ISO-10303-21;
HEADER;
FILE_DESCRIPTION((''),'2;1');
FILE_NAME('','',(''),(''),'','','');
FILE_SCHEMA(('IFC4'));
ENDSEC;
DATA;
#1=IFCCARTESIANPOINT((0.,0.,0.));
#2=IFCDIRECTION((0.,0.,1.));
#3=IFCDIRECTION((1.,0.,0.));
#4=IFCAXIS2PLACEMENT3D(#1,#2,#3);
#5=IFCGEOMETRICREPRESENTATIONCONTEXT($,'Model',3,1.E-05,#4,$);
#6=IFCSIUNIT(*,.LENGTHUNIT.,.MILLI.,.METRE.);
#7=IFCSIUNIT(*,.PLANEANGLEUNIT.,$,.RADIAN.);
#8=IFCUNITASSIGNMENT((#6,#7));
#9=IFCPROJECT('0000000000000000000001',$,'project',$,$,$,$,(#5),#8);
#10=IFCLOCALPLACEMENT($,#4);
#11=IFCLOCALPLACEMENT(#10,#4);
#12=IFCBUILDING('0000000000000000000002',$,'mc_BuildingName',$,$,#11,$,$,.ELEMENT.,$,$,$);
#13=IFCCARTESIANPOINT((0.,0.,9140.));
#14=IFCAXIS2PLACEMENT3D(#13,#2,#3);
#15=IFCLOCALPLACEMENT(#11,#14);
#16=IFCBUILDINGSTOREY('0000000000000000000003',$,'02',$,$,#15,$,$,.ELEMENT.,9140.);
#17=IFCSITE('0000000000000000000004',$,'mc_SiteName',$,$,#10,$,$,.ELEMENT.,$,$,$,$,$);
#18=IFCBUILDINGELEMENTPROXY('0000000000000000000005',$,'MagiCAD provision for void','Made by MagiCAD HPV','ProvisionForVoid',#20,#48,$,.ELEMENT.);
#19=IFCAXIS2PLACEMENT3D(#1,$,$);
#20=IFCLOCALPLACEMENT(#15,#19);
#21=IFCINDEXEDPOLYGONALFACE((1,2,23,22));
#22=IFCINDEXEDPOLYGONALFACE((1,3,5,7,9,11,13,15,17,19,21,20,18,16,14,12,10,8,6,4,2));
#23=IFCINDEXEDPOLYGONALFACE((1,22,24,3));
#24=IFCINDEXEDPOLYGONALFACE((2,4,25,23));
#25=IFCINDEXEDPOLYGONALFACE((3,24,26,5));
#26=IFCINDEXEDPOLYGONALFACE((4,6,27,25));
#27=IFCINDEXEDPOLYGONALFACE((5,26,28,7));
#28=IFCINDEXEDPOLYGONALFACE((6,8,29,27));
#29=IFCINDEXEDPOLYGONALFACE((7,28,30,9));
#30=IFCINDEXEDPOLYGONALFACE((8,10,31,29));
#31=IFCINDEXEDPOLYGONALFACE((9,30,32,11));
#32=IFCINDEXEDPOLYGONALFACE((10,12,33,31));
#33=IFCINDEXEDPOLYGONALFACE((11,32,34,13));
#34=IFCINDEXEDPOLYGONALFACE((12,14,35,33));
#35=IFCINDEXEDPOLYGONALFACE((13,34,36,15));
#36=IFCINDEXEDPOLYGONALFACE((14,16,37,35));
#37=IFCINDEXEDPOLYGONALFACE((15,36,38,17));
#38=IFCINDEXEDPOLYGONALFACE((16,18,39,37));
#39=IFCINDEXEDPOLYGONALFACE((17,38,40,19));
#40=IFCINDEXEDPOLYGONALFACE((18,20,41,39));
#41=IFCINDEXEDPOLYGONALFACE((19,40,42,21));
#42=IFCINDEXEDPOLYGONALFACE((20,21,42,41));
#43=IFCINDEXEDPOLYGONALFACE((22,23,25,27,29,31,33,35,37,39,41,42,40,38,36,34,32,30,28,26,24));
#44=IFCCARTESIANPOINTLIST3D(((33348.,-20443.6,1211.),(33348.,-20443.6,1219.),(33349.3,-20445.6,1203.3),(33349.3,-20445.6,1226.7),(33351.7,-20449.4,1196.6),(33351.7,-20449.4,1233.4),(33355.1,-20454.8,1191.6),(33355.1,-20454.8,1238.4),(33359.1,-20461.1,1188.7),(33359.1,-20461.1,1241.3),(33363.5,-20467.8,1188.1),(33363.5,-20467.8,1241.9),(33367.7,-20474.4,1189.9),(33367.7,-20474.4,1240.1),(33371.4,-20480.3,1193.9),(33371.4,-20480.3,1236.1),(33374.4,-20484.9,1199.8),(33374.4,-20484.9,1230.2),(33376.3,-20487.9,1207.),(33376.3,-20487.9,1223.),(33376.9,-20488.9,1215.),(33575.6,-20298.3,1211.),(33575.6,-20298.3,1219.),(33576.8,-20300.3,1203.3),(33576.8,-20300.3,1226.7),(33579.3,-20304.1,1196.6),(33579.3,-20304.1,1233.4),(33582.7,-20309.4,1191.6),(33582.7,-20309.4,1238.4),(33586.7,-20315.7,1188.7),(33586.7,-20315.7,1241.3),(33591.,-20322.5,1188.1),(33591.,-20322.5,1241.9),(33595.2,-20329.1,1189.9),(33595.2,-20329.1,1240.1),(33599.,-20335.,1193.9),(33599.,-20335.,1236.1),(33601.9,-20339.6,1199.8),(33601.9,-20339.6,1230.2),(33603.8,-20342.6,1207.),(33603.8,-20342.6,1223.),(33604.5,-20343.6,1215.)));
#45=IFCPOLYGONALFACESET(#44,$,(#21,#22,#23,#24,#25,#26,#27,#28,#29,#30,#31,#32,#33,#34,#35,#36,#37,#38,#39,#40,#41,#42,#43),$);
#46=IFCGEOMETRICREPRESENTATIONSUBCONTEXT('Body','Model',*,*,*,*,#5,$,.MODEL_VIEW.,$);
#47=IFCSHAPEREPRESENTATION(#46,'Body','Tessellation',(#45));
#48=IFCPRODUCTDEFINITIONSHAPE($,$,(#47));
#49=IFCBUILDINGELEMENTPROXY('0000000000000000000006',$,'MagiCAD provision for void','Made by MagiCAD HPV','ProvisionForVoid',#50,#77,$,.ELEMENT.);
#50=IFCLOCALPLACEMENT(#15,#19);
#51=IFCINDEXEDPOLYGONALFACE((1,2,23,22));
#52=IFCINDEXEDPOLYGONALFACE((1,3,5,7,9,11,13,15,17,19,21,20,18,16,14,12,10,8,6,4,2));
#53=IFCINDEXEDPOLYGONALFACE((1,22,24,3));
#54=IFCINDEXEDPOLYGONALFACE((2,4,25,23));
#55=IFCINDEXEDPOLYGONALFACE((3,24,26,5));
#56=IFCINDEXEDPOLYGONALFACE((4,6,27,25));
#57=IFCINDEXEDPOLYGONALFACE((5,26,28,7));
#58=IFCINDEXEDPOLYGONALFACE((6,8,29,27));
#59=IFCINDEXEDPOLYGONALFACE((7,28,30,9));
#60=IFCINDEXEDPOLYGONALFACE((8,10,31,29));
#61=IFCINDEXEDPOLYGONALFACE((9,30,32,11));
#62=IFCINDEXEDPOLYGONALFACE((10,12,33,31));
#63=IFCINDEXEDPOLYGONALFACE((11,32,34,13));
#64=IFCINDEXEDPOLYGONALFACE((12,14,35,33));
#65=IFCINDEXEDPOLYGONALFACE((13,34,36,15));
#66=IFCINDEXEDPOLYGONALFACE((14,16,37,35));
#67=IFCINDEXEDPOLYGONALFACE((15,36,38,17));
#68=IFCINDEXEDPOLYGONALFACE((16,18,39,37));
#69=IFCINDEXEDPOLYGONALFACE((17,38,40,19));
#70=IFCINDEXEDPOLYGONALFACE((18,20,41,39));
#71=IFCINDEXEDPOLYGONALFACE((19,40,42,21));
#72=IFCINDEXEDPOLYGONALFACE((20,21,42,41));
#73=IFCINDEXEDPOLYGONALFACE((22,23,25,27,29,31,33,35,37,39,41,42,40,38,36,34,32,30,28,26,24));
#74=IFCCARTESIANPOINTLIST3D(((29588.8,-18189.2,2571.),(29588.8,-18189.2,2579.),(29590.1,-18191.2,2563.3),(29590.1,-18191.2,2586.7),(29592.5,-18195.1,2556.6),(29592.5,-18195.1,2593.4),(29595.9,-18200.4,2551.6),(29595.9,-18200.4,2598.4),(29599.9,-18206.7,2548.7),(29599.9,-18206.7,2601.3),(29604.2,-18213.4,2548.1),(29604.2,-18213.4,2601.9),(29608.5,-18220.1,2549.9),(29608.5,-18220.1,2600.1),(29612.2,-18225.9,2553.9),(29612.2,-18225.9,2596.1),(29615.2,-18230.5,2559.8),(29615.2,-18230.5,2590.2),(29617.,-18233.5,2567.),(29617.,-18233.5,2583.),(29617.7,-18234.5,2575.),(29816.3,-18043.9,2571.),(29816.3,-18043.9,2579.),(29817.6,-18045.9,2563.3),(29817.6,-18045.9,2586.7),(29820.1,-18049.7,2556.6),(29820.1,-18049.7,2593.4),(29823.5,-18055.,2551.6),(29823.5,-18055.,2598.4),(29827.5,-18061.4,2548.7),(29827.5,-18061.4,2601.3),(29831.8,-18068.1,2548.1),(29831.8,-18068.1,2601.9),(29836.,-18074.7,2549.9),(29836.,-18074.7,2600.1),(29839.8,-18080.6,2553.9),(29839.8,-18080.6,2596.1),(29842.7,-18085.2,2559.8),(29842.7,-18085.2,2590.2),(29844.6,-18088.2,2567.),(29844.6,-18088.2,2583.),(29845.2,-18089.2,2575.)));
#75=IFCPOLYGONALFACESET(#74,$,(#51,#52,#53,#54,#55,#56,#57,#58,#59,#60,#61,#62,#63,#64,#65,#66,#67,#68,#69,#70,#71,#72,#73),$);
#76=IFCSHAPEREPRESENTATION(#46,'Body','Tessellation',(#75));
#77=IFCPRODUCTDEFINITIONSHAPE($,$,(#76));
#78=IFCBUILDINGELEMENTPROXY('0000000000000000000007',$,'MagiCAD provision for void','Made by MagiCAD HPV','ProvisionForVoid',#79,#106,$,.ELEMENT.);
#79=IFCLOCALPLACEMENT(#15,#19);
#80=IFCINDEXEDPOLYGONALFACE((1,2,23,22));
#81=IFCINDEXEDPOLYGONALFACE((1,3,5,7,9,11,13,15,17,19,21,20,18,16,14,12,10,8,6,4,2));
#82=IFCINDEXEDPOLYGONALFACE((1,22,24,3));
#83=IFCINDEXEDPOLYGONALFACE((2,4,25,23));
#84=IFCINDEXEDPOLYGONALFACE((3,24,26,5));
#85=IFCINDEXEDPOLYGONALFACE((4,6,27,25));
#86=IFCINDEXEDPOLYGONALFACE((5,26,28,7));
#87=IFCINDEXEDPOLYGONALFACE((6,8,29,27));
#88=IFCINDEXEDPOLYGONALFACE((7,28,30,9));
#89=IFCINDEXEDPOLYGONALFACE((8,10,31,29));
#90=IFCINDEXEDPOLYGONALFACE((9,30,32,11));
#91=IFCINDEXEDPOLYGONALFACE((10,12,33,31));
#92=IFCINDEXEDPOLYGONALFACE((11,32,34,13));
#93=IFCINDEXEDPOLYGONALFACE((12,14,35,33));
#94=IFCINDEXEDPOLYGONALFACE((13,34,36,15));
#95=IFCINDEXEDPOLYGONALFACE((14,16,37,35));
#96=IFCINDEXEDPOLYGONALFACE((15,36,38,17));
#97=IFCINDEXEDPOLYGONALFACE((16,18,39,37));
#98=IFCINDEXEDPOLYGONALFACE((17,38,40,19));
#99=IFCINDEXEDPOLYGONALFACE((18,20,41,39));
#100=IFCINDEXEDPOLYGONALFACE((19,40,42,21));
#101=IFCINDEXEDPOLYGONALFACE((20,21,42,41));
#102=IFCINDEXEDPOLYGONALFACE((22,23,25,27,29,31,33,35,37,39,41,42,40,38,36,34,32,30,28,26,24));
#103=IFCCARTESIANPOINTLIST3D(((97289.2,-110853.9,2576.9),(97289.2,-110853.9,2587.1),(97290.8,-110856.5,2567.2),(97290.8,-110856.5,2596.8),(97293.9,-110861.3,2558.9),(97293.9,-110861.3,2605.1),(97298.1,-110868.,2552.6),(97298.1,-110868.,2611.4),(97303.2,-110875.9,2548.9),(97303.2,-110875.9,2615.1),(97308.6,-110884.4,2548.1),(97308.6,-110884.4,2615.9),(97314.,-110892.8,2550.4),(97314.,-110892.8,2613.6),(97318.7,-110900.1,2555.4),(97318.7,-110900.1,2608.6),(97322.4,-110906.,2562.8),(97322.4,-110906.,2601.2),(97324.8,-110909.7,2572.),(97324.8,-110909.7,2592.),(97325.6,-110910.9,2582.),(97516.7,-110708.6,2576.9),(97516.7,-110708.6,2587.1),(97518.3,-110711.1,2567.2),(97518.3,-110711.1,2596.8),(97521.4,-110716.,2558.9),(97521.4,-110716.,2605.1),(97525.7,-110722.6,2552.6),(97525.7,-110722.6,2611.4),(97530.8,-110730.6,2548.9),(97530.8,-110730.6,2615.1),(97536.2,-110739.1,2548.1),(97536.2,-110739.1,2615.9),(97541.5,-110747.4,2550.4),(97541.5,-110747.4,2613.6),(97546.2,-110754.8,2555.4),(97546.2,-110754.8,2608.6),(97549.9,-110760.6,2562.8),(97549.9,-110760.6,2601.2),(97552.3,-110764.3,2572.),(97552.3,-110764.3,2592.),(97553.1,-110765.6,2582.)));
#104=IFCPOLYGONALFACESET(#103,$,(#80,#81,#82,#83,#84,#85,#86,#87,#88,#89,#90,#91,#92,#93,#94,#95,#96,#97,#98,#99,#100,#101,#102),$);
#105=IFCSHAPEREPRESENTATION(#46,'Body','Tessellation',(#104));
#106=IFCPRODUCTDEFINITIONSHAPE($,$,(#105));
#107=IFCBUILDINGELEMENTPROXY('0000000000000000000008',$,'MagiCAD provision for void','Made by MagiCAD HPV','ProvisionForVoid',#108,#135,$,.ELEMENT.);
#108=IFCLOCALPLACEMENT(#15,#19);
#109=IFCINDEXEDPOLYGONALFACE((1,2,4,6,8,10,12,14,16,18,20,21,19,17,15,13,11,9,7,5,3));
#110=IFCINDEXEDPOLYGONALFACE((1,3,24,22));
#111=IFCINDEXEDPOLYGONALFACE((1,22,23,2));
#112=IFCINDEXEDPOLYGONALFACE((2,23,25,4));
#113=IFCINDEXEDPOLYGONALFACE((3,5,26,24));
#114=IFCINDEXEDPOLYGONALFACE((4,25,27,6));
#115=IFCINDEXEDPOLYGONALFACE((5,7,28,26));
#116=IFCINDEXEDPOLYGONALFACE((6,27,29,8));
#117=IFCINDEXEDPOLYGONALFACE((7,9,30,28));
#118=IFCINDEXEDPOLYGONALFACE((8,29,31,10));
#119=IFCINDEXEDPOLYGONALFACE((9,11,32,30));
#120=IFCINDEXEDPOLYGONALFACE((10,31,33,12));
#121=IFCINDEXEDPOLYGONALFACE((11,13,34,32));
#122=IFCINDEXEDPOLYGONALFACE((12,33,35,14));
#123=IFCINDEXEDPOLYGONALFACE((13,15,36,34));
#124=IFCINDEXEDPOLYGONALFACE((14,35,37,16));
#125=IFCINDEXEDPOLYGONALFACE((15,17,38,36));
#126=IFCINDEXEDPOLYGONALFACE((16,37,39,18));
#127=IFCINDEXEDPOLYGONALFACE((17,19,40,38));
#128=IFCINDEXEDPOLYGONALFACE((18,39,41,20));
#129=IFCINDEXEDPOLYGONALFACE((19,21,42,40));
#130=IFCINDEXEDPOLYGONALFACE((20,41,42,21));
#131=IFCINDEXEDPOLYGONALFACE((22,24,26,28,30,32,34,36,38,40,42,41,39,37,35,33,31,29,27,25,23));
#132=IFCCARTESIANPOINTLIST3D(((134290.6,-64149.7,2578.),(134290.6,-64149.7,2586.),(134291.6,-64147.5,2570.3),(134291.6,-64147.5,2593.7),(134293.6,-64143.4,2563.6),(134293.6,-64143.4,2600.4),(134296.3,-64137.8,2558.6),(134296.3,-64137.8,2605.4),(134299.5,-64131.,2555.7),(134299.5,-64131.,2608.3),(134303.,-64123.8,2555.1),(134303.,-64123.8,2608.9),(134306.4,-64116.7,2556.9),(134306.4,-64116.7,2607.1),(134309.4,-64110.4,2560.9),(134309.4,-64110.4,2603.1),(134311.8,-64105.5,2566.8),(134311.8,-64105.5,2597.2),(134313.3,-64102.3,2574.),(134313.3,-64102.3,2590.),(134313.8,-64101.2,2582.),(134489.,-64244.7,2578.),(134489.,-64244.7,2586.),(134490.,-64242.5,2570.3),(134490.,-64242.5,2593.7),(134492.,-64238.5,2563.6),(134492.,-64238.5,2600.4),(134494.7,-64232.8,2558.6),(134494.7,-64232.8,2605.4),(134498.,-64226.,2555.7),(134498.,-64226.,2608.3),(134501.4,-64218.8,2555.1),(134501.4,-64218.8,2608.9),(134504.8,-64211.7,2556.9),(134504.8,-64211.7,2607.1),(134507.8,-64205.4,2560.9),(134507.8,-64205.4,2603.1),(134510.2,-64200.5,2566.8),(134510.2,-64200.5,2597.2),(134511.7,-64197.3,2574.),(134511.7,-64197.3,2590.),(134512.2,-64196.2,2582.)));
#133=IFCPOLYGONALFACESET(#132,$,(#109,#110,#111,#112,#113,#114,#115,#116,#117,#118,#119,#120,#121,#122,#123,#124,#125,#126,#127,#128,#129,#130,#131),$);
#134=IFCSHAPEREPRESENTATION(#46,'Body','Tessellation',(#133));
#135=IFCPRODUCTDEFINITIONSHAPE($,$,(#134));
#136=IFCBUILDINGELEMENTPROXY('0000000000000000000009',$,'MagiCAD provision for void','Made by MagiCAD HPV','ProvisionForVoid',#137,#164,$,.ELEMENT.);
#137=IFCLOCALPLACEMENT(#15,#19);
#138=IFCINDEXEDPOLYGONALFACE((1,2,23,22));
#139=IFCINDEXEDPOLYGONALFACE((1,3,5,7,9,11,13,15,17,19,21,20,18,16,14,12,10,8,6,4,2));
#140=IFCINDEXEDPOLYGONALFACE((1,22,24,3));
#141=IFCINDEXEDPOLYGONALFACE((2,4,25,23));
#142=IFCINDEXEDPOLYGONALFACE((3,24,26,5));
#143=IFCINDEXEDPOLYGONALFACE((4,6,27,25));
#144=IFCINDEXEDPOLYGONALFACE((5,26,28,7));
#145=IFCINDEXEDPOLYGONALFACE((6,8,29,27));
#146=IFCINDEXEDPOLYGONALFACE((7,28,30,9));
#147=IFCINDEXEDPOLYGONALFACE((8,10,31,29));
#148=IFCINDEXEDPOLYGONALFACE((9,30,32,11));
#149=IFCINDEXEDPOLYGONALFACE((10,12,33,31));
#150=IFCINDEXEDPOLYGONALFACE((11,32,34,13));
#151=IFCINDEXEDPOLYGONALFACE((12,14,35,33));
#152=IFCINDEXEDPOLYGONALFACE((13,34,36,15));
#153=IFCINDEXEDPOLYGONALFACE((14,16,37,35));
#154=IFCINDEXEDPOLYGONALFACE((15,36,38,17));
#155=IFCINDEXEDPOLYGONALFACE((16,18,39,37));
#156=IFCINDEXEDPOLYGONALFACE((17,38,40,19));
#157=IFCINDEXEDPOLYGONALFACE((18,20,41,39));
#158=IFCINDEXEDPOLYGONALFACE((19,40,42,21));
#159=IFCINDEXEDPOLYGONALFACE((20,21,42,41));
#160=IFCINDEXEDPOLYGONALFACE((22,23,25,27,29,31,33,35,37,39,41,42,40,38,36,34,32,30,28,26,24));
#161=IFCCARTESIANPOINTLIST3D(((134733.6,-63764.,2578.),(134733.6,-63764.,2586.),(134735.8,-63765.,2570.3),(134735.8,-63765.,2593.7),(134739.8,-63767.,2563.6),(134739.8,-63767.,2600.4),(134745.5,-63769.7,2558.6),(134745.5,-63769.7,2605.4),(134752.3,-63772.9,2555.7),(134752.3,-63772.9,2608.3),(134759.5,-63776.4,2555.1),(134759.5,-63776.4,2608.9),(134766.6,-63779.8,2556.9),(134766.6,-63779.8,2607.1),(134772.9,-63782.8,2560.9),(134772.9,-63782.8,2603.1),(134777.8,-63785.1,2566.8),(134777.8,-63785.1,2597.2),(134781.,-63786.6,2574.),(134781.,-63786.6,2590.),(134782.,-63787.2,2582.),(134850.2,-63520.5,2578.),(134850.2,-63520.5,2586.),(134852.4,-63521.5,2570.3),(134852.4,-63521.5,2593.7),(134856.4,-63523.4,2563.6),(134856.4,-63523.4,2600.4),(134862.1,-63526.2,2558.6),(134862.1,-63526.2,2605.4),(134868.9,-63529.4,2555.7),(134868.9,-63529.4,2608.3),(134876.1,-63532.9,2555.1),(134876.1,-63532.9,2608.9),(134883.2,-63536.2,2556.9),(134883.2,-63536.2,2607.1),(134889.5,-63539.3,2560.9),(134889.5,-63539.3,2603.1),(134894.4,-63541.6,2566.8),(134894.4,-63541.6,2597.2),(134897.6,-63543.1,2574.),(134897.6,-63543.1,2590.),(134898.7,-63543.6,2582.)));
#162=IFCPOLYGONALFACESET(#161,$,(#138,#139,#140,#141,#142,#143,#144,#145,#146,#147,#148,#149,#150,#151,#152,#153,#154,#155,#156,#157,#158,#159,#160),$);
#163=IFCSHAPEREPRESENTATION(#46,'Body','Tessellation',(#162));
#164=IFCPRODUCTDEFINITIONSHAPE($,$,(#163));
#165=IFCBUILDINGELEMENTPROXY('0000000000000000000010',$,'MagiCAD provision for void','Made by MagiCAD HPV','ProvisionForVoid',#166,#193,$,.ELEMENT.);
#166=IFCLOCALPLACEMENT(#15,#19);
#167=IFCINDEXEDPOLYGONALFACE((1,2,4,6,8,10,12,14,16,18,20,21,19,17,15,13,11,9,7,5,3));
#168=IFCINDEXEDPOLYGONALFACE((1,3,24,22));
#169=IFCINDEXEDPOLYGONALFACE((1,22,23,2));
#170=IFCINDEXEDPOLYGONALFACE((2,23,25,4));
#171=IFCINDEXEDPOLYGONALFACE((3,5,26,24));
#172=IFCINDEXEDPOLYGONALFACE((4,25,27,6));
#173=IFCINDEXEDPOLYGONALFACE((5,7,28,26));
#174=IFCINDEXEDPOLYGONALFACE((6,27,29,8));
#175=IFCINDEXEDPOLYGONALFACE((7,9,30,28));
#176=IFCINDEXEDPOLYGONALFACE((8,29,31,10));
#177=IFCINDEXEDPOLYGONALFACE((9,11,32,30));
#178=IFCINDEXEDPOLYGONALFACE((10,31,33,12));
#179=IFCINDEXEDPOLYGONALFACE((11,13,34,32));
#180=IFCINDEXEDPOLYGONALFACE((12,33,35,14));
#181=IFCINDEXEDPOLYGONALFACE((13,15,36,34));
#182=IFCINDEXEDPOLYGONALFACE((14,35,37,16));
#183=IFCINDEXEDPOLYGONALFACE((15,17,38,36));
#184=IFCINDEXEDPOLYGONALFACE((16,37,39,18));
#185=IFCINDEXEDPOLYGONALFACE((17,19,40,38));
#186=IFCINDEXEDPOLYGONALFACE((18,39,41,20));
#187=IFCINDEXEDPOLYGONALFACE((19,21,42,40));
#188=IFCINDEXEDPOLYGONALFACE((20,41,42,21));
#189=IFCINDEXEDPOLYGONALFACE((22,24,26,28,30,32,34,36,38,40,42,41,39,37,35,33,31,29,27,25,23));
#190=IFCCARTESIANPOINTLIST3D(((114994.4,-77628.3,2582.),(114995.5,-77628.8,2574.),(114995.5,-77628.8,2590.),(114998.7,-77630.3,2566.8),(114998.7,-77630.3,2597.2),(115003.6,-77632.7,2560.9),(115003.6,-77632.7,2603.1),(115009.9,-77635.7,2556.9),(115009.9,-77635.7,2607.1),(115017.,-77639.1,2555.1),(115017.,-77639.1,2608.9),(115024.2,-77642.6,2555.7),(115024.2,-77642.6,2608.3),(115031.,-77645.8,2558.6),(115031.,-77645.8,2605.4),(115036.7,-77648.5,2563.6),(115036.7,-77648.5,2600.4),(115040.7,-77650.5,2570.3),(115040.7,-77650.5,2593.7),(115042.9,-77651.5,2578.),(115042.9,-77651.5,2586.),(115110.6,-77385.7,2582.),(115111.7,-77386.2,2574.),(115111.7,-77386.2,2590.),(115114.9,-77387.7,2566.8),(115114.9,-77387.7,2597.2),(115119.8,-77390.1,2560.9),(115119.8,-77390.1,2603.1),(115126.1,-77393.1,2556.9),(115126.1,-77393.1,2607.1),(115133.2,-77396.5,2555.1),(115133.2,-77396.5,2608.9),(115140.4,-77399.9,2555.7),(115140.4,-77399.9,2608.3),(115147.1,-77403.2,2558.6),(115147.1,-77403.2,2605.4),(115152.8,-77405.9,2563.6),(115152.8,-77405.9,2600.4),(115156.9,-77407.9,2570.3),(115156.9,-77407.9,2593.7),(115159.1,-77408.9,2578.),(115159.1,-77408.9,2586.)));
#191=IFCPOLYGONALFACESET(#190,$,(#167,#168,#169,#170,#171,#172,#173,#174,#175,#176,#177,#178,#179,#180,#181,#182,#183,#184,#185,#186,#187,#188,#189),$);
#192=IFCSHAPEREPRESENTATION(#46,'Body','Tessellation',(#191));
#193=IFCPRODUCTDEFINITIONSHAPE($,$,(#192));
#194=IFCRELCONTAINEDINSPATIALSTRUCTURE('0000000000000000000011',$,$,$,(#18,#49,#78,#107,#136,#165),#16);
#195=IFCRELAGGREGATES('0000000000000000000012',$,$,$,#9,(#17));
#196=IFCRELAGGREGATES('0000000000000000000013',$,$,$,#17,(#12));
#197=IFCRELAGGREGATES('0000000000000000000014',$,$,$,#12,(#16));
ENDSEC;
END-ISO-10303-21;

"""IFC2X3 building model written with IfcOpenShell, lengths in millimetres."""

from ifc_helpers import new_model, si_unit, frame, origin_with_axes, origin_2d_with_axis, place, context, subcontext, project, spatial, circle, extrude, source, transform, mapped, element, save


model = new_model("IFC2X3")

# Units and contexts
model_context = context("Model", 3, precision=1e-05, world=origin_with_axes())
body_context = subcontext(model_context, "Body", "Model", "MODEL_VIEW")
ifc_project = project(units=[si_unit("LENGTHUNIT", "METRE", prefix="MILLI"), si_unit("PLANEANGLEUNIT", "RADIAN")], contexts=[model_context])

# Site, building, storey
site_placement = place(None, origin_with_axes())
site = spatial("IfcSite", under=ifc_project, at=site_placement, Name="mc_SiteName", CompositionType="ELEMENT")
building_placement = place(site_placement, origin_with_axes())
building = spatial("IfcBuilding", under=site, at=building_placement, Name="mc_BuildingName", CompositionType="ELEMENT")
storey_placement = place(building_placement, frame((0.0, 0.0, 9140.0), z_axis=(0.0, 0.0, 1.0), x_axis=(1.0, 0.0, 0.0)))
storey = spatial("IfcBuildingStorey", under=building, at=storey_placement, Name="02", CompositionType="ELEMENT", Elevation=9140.0)

# Building element proxies
shared_shape_1 = source(origin_with_axes(), body_context, "Body", "SweptSolid", [
    extrude(circle(Radius=27.0, at=origin_2d_with_axis()), frame((0.0, 0.0, 0.0), z_axis=(1.0, 0.0, 0.0), x_axis=(0.0, 1.0, 0.0)), (0.0, 0.0, 1.0), 270.0),
])
proxy_1_placement = place(storey_placement, frame((33589.9, -20320.8, 1215.0), z_axis=(0.0, 0.0, 1.0), x_axis=(-0.842809, -0.538213, 0.0)))
element("IfcBuildingElementProxy", 1, at=proxy_1_placement, inside=storey, Name="MagiCAD provision for void", Description="Made by MagiCAD HPV", ObjectType="ProvisionForVoid", CompositionType="ELEMENT", context=body_context, shape_type="MappedRepresentation", body=[
    mapped(shared_shape_1, transform((0.0, 0.0, 0.0), scale=1.0)),
])
shared_shape_2 = source(origin_with_axes(), body_context, "Body", "SweptSolid", [
    extrude(circle(Radius=27.0, at=origin_2d_with_axis()), frame((0.0, 0.0, 0.0), z_axis=(1.0, 0.0, 0.0), x_axis=(0.0, 1.0, 0.0)), (0.0, 0.0, 1.0), 270.0),
])
proxy_2_placement = place(storey_placement, frame((29830.7, -18066.4, 2575.0), z_axis=(0.0, 0.0, 1.0), x_axis=(-0.842809, -0.538213, 0.0)))
element("IfcBuildingElementProxy", 2, at=proxy_2_placement, inside=storey, Name="MagiCAD provision for void", Description="Made by MagiCAD HPV", ObjectType="ProvisionForVoid", CompositionType="ELEMENT", context=body_context, shape_type="MappedRepresentation", body=[
    mapped(shared_shape_2, transform((0.0, 0.0, 0.0), scale=1.0)),
])
shared_shape_3 = source(origin_with_axes(), body_context, "Body", "SweptSolid", [
    extrude(circle(Radius=34.0, at=origin_2d_with_axis()), frame((0.0, 0.0, 0.0), z_axis=(1.0, 0.0, 0.0), x_axis=(0.0, 1.0, 0.0)), (0.0, 0.0, 1.0), 270.0),
])
proxy_3_placement = place(storey_placement, frame((97534.8, -110737.0, 2582.0), z_axis=(0.0, 0.0, 1.0), x_axis=(-0.842809, -0.538213, 0.0)))
element("IfcBuildingElementProxy", 3, at=proxy_3_placement, inside=storey, Name="MagiCAD provision for void", Description="Made by MagiCAD HPV", ObjectType="ProvisionForVoid", CompositionType="ELEMENT", context=body_context, shape_type="MappedRepresentation", body=[
    mapped(shared_shape_3, transform((0.0, 0.0, 0.0), scale=1.0)),
])
shared_shape_4 = source(origin_with_axes(), body_context, "Body", "SweptSolid", [
    extrude(circle(Radius=27.0, at=origin_2d_with_axis()), frame((0.0, 0.0, 0.0), z_axis=(1.0, 0.0, 0.0), x_axis=(0.0, 1.0, 0.0)), (0.0, 0.0, 1.0), 220.0),
])
proxy_4_placement = place(storey_placement, frame((134302.1, -64125.6, 2582.0), z_axis=(0.0, 0.0, 1.0), x_axis=(0.901941, -0.431859, 0.0)))
element("IfcBuildingElementProxy", 4, at=proxy_4_placement, inside=storey, Name="MagiCAD provision for void", Description="Made by MagiCAD HPV", ObjectType="ProvisionForVoid", CompositionType="ELEMENT", context=body_context, shape_type="MappedRepresentation", body=[
    mapped(shared_shape_4, transform((0.0, 0.0, 0.0), scale=1.0)),
])
shared_shape_5 = source(origin_with_axes(), body_context, "Body", "SweptSolid", [
    extrude(circle(Radius=27.0, at=origin_2d_with_axis()), frame((0.0, 0.0, 0.0), z_axis=(1.0, 0.0, 0.0), x_axis=(0.0, 1.0, 0.0)), (0.0, 0.0, 1.0), 270.0),
])
proxy_5_placement = place(storey_placement, frame((134874.3, -63532.0, 2582.0), z_axis=(0.0, 0.0, 1.0), x_axis=(-0.431882, -0.90193, 0.0)))
element("IfcBuildingElementProxy", 5, at=proxy_5_placement, inside=storey, Name="MagiCAD provision for void", Description="Made by MagiCAD HPV", ObjectType="ProvisionForVoid", CompositionType="ELEMENT", context=body_context, shape_type="MappedRepresentation", body=[
    mapped(shared_shape_5, transform((0.0, 0.0, 0.0), scale=1.0)),
])
shared_shape_6 = source(origin_with_axes(), body_context, "Body", "SweptSolid", [
    extrude(circle(Radius=27.0, at=origin_2d_with_axis()), frame((0.0, 0.0, 0.0), z_axis=(1.0, 0.0, 0.0), x_axis=(0.0, 1.0, 0.0)), (0.0, 0.0, 1.0), 269.0),
])
proxy_6_placement = place(storey_placement, frame((115018.8, -77640.0, 2582.0), z_axis=(0.0, 0.0, 1.0), x_axis=(0.431859, 0.901941, 0.0)))
element("IfcBuildingElementProxy", 6, at=proxy_6_placement, inside=storey, Name="MagiCAD provision for void", Description="Made by MagiCAD HPV", ObjectType="ProvisionForVoid", CompositionType="ELEMENT", context=body_context, shape_type="MappedRepresentation", body=[
    mapped(shared_shape_6, transform((0.0, 0.0, 0.0), scale=1.0)),
])

save(model, "model.ifc")
